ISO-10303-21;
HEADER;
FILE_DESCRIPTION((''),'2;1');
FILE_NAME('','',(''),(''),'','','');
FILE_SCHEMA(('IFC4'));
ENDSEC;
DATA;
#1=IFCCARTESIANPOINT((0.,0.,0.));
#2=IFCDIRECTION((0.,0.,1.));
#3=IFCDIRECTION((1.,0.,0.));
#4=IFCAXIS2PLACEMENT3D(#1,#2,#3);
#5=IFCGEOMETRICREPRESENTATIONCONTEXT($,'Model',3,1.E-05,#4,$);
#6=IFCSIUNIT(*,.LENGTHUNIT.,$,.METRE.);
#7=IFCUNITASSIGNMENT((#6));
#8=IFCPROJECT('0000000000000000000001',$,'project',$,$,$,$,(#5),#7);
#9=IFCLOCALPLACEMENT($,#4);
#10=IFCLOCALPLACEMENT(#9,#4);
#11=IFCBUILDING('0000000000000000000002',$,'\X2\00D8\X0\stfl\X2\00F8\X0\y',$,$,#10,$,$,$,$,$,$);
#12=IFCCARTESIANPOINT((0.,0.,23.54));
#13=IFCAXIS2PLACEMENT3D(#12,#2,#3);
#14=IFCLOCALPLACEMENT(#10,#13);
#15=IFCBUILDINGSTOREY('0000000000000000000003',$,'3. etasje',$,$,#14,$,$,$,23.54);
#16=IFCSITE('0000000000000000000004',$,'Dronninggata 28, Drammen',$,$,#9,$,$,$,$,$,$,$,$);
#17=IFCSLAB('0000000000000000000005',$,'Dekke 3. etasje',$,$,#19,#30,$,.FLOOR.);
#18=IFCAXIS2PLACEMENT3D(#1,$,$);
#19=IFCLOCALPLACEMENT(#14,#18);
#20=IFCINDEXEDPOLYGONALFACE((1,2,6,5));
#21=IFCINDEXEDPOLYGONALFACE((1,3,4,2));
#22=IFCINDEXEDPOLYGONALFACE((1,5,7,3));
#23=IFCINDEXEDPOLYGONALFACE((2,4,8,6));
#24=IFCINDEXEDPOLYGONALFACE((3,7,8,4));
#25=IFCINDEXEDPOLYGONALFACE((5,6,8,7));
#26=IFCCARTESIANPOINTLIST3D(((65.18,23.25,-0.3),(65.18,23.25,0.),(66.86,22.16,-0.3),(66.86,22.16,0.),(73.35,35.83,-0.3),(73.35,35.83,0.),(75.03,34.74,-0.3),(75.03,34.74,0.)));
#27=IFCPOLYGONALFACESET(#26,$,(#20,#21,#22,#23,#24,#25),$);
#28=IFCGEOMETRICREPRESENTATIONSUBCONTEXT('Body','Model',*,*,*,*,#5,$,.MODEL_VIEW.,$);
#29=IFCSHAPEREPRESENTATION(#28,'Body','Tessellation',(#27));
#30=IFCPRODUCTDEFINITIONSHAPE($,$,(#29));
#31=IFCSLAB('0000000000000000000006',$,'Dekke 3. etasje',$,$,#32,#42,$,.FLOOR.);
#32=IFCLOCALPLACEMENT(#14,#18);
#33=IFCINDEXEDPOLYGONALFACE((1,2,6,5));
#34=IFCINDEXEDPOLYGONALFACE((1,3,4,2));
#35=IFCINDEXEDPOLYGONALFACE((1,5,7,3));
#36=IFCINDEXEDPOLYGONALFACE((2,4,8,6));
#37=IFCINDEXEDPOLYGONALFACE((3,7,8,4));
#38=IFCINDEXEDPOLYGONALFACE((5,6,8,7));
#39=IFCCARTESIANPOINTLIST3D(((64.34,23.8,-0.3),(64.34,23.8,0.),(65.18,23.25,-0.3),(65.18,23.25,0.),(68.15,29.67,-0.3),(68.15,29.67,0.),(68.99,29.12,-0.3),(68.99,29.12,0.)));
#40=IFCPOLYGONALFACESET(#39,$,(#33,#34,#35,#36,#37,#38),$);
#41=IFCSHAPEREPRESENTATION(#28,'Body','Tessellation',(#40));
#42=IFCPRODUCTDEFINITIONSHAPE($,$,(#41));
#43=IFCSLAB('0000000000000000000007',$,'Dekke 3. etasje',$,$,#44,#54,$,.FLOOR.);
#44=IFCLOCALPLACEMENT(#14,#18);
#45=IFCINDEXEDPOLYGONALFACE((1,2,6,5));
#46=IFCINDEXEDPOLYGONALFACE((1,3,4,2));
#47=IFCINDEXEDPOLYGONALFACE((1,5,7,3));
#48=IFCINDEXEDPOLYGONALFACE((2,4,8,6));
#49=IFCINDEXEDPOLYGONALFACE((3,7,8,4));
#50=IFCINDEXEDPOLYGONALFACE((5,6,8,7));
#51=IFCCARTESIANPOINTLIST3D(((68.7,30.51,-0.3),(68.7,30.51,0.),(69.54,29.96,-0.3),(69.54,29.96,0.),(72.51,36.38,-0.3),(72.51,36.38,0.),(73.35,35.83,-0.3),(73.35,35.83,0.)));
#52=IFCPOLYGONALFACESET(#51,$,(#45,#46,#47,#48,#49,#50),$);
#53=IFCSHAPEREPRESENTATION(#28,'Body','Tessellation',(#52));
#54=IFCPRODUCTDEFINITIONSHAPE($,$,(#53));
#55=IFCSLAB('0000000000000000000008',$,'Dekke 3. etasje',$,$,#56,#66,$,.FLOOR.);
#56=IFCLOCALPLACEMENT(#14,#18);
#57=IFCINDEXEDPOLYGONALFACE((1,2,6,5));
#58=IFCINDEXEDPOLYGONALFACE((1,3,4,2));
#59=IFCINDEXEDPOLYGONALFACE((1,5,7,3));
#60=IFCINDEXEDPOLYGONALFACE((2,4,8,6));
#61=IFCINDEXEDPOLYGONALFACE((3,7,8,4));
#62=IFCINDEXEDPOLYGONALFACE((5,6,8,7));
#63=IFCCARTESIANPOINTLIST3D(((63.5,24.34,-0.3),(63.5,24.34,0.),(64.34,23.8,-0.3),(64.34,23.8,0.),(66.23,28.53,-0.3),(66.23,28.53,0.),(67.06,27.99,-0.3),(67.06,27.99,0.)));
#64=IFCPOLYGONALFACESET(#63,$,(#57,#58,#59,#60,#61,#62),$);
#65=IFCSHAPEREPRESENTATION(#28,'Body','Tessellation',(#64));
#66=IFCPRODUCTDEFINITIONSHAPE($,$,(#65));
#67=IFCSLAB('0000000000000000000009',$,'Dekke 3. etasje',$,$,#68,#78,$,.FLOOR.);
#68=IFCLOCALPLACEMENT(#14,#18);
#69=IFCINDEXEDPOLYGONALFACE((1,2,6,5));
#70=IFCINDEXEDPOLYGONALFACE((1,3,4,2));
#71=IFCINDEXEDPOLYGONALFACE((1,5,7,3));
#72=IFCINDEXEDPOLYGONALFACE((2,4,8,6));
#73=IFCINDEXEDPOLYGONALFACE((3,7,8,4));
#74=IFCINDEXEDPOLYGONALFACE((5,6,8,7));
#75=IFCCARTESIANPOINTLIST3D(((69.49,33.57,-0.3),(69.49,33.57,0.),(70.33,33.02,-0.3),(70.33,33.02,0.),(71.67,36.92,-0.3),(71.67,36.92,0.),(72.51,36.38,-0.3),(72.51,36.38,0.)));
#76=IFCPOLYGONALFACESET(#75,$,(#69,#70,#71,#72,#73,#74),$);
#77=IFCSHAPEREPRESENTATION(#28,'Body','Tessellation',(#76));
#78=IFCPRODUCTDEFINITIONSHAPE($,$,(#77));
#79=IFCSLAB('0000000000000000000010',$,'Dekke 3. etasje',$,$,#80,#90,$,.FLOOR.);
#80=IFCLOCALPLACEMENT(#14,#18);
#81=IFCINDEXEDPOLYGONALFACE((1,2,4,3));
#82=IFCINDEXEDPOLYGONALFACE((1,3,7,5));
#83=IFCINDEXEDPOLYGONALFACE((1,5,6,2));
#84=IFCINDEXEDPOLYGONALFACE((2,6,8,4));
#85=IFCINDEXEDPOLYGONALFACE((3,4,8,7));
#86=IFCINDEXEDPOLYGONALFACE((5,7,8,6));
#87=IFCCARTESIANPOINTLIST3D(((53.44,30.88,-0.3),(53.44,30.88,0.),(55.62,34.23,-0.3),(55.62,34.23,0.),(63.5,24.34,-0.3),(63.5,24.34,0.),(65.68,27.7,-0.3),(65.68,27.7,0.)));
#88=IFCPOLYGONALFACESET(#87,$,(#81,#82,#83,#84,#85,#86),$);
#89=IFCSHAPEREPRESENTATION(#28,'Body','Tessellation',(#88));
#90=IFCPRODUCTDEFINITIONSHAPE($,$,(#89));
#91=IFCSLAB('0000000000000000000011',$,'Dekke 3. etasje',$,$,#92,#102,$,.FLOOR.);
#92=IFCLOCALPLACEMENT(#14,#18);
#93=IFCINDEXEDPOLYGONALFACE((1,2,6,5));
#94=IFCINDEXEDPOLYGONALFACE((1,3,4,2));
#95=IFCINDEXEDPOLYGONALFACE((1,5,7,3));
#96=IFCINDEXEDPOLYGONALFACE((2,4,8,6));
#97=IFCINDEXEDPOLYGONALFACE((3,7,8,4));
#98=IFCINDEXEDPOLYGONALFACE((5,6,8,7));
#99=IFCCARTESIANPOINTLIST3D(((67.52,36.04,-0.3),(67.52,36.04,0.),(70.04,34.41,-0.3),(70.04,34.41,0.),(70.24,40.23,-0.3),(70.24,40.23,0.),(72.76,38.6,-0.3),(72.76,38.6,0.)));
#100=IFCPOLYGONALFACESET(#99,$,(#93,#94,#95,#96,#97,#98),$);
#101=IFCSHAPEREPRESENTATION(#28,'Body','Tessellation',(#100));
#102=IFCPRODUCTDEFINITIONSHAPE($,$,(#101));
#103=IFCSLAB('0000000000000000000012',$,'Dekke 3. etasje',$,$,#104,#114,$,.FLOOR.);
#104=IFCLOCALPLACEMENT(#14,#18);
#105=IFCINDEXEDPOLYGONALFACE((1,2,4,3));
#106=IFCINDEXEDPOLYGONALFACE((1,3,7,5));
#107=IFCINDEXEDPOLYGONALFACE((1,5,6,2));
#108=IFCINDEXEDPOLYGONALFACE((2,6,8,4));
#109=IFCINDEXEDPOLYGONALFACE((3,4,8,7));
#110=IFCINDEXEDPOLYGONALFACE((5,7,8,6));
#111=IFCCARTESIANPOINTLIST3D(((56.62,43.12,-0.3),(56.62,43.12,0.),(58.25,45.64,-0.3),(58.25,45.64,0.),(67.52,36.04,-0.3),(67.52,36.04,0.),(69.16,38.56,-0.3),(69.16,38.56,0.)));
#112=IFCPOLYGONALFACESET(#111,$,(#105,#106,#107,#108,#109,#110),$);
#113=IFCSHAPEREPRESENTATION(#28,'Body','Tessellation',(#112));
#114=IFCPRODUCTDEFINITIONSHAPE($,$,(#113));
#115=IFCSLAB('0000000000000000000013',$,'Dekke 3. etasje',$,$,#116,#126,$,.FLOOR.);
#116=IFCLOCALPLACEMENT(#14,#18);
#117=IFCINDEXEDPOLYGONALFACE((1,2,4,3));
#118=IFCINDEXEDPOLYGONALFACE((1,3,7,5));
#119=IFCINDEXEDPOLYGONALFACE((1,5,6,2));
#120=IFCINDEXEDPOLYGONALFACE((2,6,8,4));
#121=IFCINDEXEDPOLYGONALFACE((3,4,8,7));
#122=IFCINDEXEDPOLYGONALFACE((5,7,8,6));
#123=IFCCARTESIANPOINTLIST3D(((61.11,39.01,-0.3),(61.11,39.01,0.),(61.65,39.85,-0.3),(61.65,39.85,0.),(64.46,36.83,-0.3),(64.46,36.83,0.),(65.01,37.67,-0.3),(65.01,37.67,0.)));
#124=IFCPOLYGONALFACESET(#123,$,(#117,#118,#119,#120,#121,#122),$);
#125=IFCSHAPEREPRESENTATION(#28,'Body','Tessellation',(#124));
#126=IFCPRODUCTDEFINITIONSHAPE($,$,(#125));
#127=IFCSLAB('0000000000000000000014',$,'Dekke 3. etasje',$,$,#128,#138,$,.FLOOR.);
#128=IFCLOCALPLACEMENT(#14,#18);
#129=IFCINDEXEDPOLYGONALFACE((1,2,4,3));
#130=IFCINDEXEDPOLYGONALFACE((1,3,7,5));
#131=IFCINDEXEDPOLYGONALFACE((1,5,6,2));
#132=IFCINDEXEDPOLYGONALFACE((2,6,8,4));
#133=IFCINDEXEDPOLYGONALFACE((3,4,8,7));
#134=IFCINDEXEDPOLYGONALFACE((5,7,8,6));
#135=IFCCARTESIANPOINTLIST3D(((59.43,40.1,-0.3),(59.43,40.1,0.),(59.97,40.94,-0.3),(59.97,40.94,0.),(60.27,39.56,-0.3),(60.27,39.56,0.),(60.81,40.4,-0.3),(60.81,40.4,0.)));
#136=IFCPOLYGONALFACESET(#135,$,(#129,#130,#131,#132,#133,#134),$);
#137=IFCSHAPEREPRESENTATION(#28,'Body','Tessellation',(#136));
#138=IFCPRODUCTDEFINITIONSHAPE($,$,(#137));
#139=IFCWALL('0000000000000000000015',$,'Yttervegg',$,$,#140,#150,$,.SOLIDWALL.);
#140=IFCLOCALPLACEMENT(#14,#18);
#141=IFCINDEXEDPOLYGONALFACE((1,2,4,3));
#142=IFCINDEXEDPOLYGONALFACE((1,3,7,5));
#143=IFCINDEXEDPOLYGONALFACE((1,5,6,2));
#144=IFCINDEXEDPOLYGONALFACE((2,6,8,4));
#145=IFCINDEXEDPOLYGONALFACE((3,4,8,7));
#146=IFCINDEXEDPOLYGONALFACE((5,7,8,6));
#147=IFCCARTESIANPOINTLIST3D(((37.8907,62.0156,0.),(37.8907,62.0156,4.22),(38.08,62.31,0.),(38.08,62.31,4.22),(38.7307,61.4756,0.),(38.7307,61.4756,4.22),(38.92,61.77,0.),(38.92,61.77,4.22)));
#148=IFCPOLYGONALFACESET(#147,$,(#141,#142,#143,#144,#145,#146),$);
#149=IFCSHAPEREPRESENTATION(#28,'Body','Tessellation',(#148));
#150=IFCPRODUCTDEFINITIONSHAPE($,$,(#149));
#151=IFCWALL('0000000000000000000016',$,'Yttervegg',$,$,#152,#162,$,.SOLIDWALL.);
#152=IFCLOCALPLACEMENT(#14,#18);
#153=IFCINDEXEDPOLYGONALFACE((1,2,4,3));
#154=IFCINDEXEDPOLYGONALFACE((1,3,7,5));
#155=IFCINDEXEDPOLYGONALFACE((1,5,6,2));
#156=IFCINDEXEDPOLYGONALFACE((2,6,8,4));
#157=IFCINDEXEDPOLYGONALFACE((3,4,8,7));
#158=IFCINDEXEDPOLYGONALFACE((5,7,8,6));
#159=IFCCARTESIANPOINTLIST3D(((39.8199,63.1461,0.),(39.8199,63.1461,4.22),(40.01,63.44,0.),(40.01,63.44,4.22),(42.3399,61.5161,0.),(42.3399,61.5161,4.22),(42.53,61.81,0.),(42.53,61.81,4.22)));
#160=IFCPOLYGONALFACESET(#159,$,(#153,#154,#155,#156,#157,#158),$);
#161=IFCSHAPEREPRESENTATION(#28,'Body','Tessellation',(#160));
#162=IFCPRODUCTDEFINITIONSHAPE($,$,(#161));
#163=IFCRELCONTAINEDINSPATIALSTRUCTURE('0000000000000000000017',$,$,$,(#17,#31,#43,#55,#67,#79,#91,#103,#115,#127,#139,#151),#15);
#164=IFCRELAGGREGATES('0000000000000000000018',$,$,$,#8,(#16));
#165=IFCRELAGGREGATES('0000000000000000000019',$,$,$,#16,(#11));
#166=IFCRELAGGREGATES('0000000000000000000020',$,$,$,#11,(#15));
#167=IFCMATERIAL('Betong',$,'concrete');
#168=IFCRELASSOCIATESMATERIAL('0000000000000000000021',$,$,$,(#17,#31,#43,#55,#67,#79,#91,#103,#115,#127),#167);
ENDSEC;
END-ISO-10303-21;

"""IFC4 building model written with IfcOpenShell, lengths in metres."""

from ifc_helpers import new_model, si_unit, frame, origin_with_axes, place, context, subcontext, project, spatial, polyline, outline, extrude, material, element, save


model = new_model("IFC4")

# Units and contexts
model_context = context("Model", 3, precision=1e-05, world=origin_with_axes())
body_context = subcontext(model_context, "Body", "Model", "MODEL_VIEW")
ifc_project = project(units=[si_unit("LENGTHUNIT", "METRE")], contexts=[model_context])

# Site, building, storey
site_placement = place(None, origin_with_axes())
site = spatial("IfcSite", under=ifc_project, at=site_placement, Name="Dronninggata 28, Drammen")
building_placement = place(site_placement, origin_with_axes())
building = spatial("IfcBuilding", under=site, at=building_placement, Name="Østfløy")
storey_placement = place(building_placement, frame((0.0, 0.0, 23.54), z_axis=(0.0, 0.0, 1.0), x_axis=(1.0, 0.0, 0.0)))
storey = spatial("IfcBuildingStorey", under=building, at=storey_placement, Name="3. etasje", Elevation=23.54)

# Slabs
ifc_material = material(Name="Betong", Category="concrete")
slab_1_placement = place(storey_placement, frame((0.0, 0.0, -23.54), z_axis=(0.0, 0.0, 1.0), x_axis=(1.0, 0.0, 0.0)))
element("IfcSlab", 1, at=slab_1_placement, inside=storey, material=ifc_material, Name="Dekke 3. etasje", PredefinedType="FLOOR", context=body_context, shape_type="SweptSolid", body=[
    extrude(outline(polyline([(66.86, 22.16), (75.03, 34.74), (73.35, 35.83), (65.18, 23.25), (66.86, 22.16)])), frame((0.0, 0.0, 23.24)), (0.0, 0.0, 1.0), 0.3),
])
slab_2_placement = place(storey_placement, frame((0.0, 0.0, -23.54), z_axis=(0.0, 0.0, 1.0), x_axis=(1.0, 0.0, 0.0)))
element("IfcSlab", 2, at=slab_2_placement, inside=storey, material=ifc_material, Name="Dekke 3. etasje", PredefinedType="FLOOR", context=body_context, shape_type="SweptSolid", body=[
    extrude(outline(polyline([(65.18, 23.25), (68.99, 29.12), (68.15, 29.67), (64.34, 23.8), (65.18, 23.25)])), frame((0.0, 0.0, 23.24)), (0.0, 0.0, 1.0), 0.3),
])
slab_3_placement = place(storey_placement, frame((0.0, 0.0, -23.54), z_axis=(0.0, 0.0, 1.0), x_axis=(1.0, 0.0, 0.0)))
element("IfcSlab", 3, at=slab_3_placement, inside=storey, material=ifc_material, Name="Dekke 3. etasje", PredefinedType="FLOOR", context=body_context, shape_type="SweptSolid", body=[
    extrude(outline(polyline([(69.54, 29.96), (73.35, 35.83), (72.51, 36.38), (68.7, 30.51), (69.54, 29.96)])), frame((0.0, 0.0, 23.24)), (0.0, 0.0, 1.0), 0.3),
])
slab_4_placement = place(storey_placement, frame((0.0, 0.0, -23.54), z_axis=(0.0, 0.0, 1.0), x_axis=(1.0, 0.0, 0.0)))
element("IfcSlab", 4, at=slab_4_placement, inside=storey, material=ifc_material, Name="Dekke 3. etasje", PredefinedType="FLOOR", context=body_context, shape_type="SweptSolid", body=[
    extrude(outline(polyline([(64.34, 23.8), (67.06, 27.99), (66.23, 28.53), (63.5, 24.34), (64.34, 23.8)])), frame((0.0, 0.0, 23.24)), (0.0, 0.0, 1.0), 0.3),
])
slab_5_placement = place(storey_placement, frame((0.0, 0.0, -23.54), z_axis=(0.0, 0.0, 1.0), x_axis=(1.0, 0.0, 0.0)))
element("IfcSlab", 5, at=slab_5_placement, inside=storey, material=ifc_material, Name="Dekke 3. etasje", PredefinedType="FLOOR", context=body_context, shape_type="SweptSolid", body=[
    extrude(outline(polyline([(70.33, 33.02), (72.51, 36.38), (71.67, 36.92), (69.49, 33.57), (70.33, 33.02)])), frame((0.0, 0.0, 23.24)), (0.0, 0.0, 1.0), 0.3),
])
slab_6_placement = place(storey_placement, frame((0.0, 0.0, -23.54), z_axis=(0.0, 0.0, 1.0), x_axis=(1.0, 0.0, 0.0)))
element("IfcSlab", 6, at=slab_6_placement, inside=storey, material=ifc_material, Name="Dekke 3. etasje", PredefinedType="FLOOR", context=body_context, shape_type="SweptSolid", body=[
    extrude(outline(polyline([(63.5, 24.34), (65.68, 27.7), (55.62, 34.23), (53.44, 30.88), (63.5, 24.34)])), frame((0.0, 0.0, 23.24)), (0.0, 0.0, 1.0), 0.3),
])
slab_7_placement = place(storey_placement, frame((0.0, 0.0, -23.54), z_axis=(0.0, 0.0, 1.0), x_axis=(1.0, 0.0, 0.0)))
element("IfcSlab", 7, at=slab_7_placement, inside=storey, material=ifc_material, Name="Dekke 3. etasje", PredefinedType="FLOOR", context=body_context, shape_type="SweptSolid", body=[
    extrude(outline(polyline([(70.04, 34.41), (72.76, 38.6), (70.24, 40.23), (67.52, 36.04), (70.04, 34.41)])), frame((0.0, 0.0, 23.24)), (0.0, 0.0, 1.0), 0.3),
])
slab_8_placement = place(storey_placement, frame((0.0, 0.0, -23.54), z_axis=(0.0, 0.0, 1.0), x_axis=(1.0, 0.0, 0.0)))
element("IfcSlab", 8, at=slab_8_placement, inside=storey, material=ifc_material, Name="Dekke 3. etasje", PredefinedType="FLOOR", context=body_context, shape_type="SweptSolid", body=[
    extrude(outline(polyline([(67.52, 36.04), (69.16, 38.56), (58.25, 45.64), (56.62, 43.12), (67.52, 36.04)])), frame((0.0, 0.0, 23.24)), (0.0, 0.0, 1.0), 0.3),
])
slab_9_placement = place(storey_placement, frame((0.0, 0.0, -23.54), z_axis=(0.0, 0.0, 1.0), x_axis=(1.0, 0.0, 0.0)))
element("IfcSlab", 9, at=slab_9_placement, inside=storey, material=ifc_material, Name="Dekke 3. etasje", PredefinedType="FLOOR", context=body_context, shape_type="SweptSolid", body=[
    extrude(outline(polyline([(64.46, 36.83), (65.01, 37.67), (61.65, 39.85), (61.11, 39.01), (64.46, 36.83)])), frame((0.0, 0.0, 23.24)), (0.0, 0.0, 1.0), 0.3),
])
slab_10_placement = place(storey_placement, frame((0.0, 0.0, -23.54), z_axis=(0.0, 0.0, 1.0), x_axis=(1.0, 0.0, 0.0)))
element("IfcSlab", 10, at=slab_10_placement, inside=storey, material=ifc_material, Name="Dekke 3. etasje", PredefinedType="FLOOR", context=body_context, shape_type="SweptSolid", body=[
    extrude(outline(polyline([(60.27, 39.56), (60.81, 40.4), (59.97, 40.94), (59.43, 40.1), (60.27, 39.56)])), frame((0.0, 0.0, 23.24)), (0.0, 0.0, 1.0), 0.3),
])

# Walls
wall_1_placement = place(storey_placement, frame((0.0, 0.0, -23.54), z_axis=(0.0, 0.0, 1.0), x_axis=(1.0, 0.0, 0.0)))
element("IfcWall", 11, at=wall_1_placement, inside=storey, Name="Yttervegg", PredefinedType="SOLIDWALL", context=body_context, shape_type="SweptSolid", body=[
    extrude(outline(polyline([(38.08, 62.31), (38.92, 61.77), (38.7307, 61.4756), (37.8907, 62.0156), (38.08, 62.31)])), frame((0.0, 0.0, 23.54)), (0.0, 0.0, 1.0), 4.22),
])
wall_2_placement = place(storey_placement, frame((0.0, 0.0, -23.54), z_axis=(0.0, 0.0, 1.0), x_axis=(1.0, 0.0, 0.0)))
element("IfcWall", 12, at=wall_2_placement, inside=storey, Name="Yttervegg", PredefinedType="SOLIDWALL", context=body_context, shape_type="SweptSolid", body=[
    extrude(outline(polyline([(40.01, 63.44), (42.53, 61.81), (42.3399, 61.5161), (39.8199, 63.1461), (40.01, 63.44)])), frame((0.0, 0.0, 23.54)), (0.0, 0.0, 1.0), 4.22),
])

save(model, "model.ifc")
